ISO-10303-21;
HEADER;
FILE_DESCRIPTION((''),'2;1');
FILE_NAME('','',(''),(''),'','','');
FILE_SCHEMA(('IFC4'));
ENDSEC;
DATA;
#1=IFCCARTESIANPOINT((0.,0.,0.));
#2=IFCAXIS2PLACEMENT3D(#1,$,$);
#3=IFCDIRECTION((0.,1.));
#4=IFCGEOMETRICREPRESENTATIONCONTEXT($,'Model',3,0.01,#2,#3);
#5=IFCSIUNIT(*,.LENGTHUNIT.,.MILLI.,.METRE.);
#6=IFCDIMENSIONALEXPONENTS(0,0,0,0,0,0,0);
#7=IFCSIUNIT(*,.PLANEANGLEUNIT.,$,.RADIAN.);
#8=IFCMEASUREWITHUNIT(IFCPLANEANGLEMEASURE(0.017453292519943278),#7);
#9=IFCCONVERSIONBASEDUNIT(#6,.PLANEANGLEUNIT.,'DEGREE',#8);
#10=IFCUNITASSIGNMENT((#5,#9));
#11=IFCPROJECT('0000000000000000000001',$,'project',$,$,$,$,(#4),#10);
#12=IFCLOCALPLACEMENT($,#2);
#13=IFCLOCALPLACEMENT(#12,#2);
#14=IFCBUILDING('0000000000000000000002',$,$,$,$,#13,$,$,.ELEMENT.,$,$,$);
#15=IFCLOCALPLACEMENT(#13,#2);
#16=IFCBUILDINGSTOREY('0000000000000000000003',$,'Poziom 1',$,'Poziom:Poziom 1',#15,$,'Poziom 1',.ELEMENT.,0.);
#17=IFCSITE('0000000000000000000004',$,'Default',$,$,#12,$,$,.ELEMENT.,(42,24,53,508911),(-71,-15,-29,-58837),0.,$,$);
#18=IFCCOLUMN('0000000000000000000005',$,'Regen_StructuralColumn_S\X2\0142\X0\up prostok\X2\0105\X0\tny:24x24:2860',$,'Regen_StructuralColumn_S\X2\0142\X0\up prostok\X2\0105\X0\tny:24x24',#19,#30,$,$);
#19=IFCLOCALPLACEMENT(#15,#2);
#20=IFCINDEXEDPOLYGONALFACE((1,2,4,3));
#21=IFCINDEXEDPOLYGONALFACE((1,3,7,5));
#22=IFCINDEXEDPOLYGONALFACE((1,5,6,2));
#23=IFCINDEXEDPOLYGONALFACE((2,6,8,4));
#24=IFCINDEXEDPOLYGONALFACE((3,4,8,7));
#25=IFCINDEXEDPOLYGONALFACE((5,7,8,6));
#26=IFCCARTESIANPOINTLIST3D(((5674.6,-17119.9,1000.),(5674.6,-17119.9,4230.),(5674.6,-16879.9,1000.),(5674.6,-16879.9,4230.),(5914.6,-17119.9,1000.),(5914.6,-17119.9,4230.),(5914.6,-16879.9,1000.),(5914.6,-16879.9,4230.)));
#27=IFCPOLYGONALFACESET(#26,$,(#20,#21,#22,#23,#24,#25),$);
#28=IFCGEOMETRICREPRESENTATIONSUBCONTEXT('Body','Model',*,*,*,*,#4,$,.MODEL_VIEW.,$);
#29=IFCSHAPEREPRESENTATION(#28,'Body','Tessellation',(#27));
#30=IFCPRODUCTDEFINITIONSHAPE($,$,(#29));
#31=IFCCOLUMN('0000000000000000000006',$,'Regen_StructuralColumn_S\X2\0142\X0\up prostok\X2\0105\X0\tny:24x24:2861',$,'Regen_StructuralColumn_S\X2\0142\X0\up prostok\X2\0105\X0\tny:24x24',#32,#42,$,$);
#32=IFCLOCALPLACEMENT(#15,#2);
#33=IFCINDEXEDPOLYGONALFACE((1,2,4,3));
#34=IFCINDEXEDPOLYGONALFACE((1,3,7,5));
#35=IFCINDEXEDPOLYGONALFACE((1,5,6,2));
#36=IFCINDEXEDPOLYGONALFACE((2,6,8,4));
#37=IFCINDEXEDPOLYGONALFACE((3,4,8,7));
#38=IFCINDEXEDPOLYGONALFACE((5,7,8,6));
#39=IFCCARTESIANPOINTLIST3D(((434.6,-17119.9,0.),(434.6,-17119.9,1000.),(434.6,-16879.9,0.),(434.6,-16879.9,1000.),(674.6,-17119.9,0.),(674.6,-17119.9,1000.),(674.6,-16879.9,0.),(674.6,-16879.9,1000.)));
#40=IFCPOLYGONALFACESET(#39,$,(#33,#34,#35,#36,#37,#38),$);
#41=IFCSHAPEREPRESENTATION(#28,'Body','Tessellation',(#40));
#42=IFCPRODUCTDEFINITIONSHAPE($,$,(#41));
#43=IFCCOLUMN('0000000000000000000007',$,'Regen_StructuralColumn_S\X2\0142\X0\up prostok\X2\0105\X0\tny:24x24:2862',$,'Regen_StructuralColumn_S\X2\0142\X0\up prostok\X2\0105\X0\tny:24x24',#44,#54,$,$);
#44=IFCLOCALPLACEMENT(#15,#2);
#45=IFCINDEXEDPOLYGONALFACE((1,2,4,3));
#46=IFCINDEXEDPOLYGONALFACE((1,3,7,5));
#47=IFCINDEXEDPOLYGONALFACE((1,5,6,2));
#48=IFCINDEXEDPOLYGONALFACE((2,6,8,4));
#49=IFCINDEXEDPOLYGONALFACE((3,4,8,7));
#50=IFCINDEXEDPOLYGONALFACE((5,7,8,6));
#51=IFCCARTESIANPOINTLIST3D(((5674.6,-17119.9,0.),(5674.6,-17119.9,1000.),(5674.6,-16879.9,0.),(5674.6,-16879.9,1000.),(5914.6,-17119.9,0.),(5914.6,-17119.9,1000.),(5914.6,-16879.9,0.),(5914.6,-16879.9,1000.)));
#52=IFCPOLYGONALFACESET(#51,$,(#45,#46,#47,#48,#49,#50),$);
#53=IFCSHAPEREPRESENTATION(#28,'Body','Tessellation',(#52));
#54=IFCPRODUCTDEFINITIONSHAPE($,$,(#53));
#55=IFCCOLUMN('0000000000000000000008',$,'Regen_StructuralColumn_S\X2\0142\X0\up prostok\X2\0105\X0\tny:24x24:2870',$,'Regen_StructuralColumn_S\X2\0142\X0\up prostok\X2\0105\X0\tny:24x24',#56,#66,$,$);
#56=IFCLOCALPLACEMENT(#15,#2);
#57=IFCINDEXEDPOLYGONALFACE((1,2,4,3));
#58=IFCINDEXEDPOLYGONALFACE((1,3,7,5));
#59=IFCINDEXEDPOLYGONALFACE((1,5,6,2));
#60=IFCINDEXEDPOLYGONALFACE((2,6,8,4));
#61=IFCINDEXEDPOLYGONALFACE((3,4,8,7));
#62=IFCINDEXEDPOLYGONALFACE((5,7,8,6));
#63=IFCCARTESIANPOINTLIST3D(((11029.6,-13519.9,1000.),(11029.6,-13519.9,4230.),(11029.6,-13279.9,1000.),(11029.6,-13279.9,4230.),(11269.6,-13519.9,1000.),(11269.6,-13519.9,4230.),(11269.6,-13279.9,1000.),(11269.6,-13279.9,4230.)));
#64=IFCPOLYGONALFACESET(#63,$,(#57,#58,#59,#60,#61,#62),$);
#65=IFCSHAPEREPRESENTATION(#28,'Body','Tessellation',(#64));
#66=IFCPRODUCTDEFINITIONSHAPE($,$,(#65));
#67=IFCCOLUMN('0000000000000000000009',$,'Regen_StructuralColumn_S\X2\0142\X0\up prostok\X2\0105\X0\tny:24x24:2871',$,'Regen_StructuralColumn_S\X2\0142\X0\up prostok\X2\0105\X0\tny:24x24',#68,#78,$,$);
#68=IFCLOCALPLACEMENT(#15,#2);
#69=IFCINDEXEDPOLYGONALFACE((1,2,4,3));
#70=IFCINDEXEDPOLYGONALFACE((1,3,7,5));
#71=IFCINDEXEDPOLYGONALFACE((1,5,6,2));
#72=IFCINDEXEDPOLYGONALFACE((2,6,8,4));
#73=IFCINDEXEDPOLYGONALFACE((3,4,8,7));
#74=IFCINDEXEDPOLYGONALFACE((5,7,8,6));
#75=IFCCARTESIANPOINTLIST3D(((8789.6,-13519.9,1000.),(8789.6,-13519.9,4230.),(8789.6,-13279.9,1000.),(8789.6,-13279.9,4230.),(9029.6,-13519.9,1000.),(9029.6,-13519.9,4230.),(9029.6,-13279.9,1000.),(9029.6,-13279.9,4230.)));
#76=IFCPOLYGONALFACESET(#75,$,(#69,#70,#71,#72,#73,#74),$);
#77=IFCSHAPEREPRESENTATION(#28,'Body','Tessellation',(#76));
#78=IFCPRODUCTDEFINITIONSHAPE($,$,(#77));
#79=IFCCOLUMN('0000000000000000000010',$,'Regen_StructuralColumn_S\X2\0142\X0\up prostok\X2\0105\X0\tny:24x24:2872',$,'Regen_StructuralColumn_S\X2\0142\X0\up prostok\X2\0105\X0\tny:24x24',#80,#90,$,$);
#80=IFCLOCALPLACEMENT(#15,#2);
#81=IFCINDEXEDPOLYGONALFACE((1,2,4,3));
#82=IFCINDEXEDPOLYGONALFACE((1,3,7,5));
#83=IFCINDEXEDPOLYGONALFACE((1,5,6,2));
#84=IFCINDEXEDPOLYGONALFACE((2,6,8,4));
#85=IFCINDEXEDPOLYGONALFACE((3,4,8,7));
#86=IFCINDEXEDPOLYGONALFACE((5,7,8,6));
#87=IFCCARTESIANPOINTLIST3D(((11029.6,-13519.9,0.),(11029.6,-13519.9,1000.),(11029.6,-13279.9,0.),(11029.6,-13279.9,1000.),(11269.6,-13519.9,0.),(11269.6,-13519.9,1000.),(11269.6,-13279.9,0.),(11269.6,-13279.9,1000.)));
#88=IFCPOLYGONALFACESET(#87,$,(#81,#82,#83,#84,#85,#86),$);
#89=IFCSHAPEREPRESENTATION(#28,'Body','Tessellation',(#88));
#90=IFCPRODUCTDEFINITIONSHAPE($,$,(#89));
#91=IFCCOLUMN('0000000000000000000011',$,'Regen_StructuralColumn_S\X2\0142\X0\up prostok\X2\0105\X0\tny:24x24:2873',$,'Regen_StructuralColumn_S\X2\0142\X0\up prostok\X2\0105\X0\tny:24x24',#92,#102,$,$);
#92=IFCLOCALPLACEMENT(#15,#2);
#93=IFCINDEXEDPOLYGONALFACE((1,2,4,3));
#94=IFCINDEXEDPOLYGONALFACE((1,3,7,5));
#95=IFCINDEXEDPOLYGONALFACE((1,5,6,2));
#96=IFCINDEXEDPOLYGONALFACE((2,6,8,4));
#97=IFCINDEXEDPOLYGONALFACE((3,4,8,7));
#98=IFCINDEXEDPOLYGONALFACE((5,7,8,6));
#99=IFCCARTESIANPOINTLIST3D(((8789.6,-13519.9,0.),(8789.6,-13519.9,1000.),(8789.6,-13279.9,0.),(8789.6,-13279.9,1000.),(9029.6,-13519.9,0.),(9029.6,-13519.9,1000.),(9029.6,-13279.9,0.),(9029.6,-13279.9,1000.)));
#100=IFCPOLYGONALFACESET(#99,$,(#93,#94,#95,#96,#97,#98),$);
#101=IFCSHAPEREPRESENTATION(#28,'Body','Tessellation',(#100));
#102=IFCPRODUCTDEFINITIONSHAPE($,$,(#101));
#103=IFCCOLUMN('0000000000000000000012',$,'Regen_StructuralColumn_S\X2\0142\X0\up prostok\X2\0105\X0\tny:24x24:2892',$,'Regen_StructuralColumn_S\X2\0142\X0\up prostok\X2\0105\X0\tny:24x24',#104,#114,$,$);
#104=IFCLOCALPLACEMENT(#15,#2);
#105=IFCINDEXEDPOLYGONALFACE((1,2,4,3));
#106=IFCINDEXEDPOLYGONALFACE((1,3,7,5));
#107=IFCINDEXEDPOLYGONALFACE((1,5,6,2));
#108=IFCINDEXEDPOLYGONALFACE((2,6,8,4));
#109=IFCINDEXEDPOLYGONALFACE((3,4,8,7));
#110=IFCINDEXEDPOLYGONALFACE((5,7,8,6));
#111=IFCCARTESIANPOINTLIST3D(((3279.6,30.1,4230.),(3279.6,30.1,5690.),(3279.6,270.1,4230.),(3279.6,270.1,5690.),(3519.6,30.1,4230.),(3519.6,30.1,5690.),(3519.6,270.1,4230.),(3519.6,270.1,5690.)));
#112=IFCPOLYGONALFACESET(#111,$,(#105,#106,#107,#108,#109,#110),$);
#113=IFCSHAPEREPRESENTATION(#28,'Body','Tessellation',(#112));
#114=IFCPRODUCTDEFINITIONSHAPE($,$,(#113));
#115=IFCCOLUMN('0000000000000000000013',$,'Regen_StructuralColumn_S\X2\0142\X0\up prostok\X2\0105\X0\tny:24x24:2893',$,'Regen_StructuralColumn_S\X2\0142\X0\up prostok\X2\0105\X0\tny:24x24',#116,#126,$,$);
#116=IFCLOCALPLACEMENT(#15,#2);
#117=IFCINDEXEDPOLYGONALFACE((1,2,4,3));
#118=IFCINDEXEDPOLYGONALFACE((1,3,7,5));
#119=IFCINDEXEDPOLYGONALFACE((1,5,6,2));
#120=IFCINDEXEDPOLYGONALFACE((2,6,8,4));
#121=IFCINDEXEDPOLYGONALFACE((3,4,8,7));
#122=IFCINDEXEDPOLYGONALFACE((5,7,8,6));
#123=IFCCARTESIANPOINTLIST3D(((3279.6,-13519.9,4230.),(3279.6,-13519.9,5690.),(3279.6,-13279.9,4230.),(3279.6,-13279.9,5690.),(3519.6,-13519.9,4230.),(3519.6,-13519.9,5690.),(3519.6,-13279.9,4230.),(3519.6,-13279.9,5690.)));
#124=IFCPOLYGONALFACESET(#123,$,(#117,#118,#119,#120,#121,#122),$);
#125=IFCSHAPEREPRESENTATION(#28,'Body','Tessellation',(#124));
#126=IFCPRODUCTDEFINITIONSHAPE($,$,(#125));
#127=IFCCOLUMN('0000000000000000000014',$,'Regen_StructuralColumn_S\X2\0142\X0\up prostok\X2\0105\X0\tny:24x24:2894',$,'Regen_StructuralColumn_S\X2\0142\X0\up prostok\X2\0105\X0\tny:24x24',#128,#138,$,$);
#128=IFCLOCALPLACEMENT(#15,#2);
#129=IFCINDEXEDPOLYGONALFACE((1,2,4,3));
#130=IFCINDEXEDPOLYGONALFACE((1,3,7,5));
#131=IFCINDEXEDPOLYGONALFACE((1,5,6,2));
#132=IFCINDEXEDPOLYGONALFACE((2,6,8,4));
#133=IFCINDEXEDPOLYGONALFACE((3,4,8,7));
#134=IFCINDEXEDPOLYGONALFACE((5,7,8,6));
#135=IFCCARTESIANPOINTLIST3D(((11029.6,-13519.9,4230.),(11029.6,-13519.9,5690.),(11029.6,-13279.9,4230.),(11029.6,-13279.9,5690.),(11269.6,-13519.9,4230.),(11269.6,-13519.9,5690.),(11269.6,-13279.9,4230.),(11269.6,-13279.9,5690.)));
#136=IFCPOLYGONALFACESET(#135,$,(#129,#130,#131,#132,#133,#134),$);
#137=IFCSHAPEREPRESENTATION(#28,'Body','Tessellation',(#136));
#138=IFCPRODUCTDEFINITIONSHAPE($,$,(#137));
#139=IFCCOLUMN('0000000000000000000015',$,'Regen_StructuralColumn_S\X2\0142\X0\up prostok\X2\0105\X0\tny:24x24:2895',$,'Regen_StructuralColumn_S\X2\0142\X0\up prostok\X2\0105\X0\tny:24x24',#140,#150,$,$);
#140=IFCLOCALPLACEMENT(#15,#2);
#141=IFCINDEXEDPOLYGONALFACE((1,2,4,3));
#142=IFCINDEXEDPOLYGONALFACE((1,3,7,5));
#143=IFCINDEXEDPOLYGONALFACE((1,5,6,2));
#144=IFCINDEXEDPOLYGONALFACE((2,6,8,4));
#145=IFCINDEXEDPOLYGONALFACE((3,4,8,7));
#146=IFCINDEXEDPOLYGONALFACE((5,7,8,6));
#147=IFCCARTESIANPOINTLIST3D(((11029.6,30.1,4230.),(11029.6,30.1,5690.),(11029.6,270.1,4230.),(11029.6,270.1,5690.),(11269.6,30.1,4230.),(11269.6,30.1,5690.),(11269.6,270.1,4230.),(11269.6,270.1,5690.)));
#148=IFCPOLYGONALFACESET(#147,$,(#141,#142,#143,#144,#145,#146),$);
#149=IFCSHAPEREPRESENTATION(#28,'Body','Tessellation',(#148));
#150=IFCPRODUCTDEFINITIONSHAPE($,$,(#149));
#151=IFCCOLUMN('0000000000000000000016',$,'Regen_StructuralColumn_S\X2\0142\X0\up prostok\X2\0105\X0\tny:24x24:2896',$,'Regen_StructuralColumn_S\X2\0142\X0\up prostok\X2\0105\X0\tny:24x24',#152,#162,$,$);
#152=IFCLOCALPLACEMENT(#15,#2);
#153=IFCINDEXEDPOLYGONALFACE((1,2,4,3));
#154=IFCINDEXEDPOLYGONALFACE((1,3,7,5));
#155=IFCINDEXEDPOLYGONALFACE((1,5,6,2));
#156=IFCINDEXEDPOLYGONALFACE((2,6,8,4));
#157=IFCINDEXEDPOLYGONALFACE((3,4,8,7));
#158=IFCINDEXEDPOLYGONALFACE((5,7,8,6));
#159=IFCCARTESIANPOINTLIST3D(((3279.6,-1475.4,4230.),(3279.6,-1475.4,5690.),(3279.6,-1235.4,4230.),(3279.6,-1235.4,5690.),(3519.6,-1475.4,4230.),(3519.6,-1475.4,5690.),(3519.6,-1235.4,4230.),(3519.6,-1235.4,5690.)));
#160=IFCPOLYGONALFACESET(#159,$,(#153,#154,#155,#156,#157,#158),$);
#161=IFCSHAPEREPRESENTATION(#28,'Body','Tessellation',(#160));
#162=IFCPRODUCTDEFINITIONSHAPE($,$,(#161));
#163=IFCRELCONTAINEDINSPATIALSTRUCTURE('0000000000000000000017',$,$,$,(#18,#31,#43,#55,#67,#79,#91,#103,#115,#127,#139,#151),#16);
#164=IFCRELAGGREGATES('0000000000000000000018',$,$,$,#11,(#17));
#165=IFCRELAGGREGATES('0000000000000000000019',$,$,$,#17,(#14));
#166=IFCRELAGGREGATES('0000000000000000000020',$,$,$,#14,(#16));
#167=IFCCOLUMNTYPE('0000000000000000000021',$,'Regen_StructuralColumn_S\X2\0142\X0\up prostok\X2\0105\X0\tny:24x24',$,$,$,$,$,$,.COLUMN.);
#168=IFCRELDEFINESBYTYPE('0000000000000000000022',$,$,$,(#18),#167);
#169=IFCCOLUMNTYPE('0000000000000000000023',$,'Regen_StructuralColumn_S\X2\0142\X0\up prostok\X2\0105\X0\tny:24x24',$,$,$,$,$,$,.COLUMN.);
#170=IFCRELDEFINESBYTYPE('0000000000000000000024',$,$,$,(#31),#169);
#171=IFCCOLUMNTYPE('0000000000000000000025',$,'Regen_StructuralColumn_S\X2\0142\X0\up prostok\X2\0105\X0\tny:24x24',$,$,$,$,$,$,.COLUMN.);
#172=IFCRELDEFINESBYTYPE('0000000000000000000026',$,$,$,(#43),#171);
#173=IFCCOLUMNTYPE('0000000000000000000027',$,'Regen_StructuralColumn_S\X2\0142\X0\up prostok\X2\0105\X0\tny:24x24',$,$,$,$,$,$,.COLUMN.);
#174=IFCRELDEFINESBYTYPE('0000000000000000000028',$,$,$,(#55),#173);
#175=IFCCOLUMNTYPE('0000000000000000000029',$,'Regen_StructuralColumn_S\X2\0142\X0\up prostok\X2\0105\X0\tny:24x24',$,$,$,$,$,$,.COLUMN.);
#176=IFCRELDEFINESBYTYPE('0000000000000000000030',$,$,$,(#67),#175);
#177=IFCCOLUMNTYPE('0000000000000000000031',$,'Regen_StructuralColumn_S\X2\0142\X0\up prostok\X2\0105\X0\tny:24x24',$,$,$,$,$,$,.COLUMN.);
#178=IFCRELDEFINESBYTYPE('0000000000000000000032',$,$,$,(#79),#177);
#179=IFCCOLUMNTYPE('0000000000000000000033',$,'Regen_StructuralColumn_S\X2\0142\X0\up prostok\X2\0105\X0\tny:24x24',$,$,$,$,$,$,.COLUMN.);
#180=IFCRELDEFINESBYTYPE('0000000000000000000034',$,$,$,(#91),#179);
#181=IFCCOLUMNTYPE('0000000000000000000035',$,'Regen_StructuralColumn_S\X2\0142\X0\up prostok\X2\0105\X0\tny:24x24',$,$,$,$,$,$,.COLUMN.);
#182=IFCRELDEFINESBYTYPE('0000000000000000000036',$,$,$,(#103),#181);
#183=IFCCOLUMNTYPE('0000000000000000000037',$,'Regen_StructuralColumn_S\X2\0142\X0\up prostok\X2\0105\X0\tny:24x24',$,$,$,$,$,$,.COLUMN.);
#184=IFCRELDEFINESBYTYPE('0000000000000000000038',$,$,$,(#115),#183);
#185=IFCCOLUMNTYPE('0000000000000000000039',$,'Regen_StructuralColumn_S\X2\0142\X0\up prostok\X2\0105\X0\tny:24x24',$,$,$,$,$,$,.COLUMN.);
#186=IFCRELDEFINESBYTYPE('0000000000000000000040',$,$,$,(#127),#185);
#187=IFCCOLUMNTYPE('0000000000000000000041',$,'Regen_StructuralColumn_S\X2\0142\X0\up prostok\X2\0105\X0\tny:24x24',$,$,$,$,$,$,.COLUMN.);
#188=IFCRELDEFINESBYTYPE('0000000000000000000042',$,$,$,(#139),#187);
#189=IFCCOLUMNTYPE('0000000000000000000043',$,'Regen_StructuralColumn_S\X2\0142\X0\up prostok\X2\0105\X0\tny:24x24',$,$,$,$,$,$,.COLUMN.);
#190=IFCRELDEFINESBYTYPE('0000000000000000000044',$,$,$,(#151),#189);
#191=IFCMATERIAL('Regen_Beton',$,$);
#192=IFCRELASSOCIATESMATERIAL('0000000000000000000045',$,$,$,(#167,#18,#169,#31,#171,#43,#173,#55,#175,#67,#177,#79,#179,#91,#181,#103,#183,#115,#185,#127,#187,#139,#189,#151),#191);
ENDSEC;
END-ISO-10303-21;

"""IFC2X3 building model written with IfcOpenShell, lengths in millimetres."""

from ifc_helpers import new_model, entity, si_unit, converted_unit, direction, frame, frame_2d, origin, place, context, subcontext, project, spatial, rectangle, extrude, source, transform, mapped, material, type_object, type_shapes, element, save


model = new_model("IFC2X3")

# Units and contexts
model_context = context("Model", 3, precision=0.01, world=origin(), true_north=direction((0.0, 1.0)))
body_context = subcontext(model_context, "Body", "Model", "MODEL_VIEW")
ifc_project = project(units=[si_unit("LENGTHUNIT", "METRE", prefix="MILLI"), converted_unit("PLANEANGLEUNIT", "DEGREE", entity("IfcPlaneAngleMeasure", 0.017453292519943278), si_unit("PLANEANGLEUNIT", "RADIAN"), dimensions=[0, 0, 0, 0, 0, 0, 0])], contexts=[model_context])

# Site, building, storey
site_placement = place(None, origin())
site = spatial("IfcSite", under=ifc_project, at=site_placement, Name="Default", CompositionType="ELEMENT", RefLatitude=(42, 24, 53, 508911), RefLongitude=(-71, -15, -29, -58837), RefElevation=0.0)
building_placement = place(site_placement, origin())
building = spatial("IfcBuilding", under=site, at=building_placement, CompositionType="ELEMENT")
storey_placement = place(building_placement, origin())
storey = spatial("IfcBuildingStorey", under=building, at=storey_placement, Name="Poziom 1", ObjectType="Poziom:Poziom 1", LongName="Poziom 1", CompositionType="ELEMENT", Elevation=0.0)

# Columns
ifc_material_1 = material(Name="Regen_Beton")
column_type_1 = type_object("IfcColumnType", Name="Regen_StructuralColumn_Słup prostokątny:24x24", PredefinedType="COLUMN", material=ifc_material_1)
shared_shape_1 = source(origin(), body_context, "Body", "SweptSolid", [
    extrude(rectangle(XDim=240.0, YDim=240.0, at=frame_2d((0.0, 0.0), x_axis=(1.0, 0.0))), frame((5794.6, -16999.9, 1000.0), z_axis=(0.0, 0.0, 1.0), x_axis=(-1.0, 0.0, 0.0)), (0.0, 0.0, 1.0), 3230.0),
])
type_shapes(column_type_1, [shared_shape_1])
column_1_placement = place(storey_placement, origin())
element("IfcColumn", 1, at=column_1_placement, inside=storey, type_object=column_type_1, material=ifc_material_1, Name="Regen_StructuralColumn_Słup prostokątny:24x24:2860", ObjectType="Regen_StructuralColumn_Słup prostokątny:24x24", context=body_context, shape_type="MappedRepresentation", body=[
    mapped(shared_shape_1, transform((0.0, 0.0, 0.0), scale=1.0)),
])
column_type_2 = type_object("IfcColumnType", Name="Regen_StructuralColumn_Słup prostokątny:24x24", PredefinedType="COLUMN", material=ifc_material_1)
shared_shape_2 = source(origin(), body_context, "Body", "SweptSolid", [
    extrude(rectangle(XDim=240.0, YDim=240.0, at=frame_2d((0.0, 0.0), x_axis=(1.0, 0.0))), frame((554.6, -16999.9, 0.0), z_axis=(0.0, 0.0, 1.0), x_axis=(-1.0, 0.0, 0.0)), (0.0, 0.0, 1.0), 1000.0),
])
type_shapes(column_type_2, [shared_shape_2])
column_2_placement = place(storey_placement, origin())
element("IfcColumn", 2, at=column_2_placement, inside=storey, type_object=column_type_2, material=ifc_material_1, Name="Regen_StructuralColumn_Słup prostokątny:24x24:2861", ObjectType="Regen_StructuralColumn_Słup prostokątny:24x24", context=body_context, shape_type="MappedRepresentation", body=[
    mapped(shared_shape_2, transform((0.0, 0.0, 0.0), scale=1.0)),
])
column_type_3 = type_object("IfcColumnType", Name="Regen_StructuralColumn_Słup prostokątny:24x24", PredefinedType="COLUMN", material=ifc_material_1)
shared_shape_3 = source(origin(), body_context, "Body", "SweptSolid", [
    extrude(rectangle(XDim=240.0, YDim=240.0, at=frame_2d((0.0, 0.0), x_axis=(1.0, 0.0))), frame((5794.6, -16999.9, 0.0), z_axis=(0.0, 0.0, 1.0), x_axis=(-1.0, 0.0, 0.0)), (0.0, 0.0, 1.0), 1000.0),
])
type_shapes(column_type_3, [shared_shape_3])
column_3_placement = place(storey_placement, origin())
element("IfcColumn", 3, at=column_3_placement, inside=storey, type_object=column_type_3, material=ifc_material_1, Name="Regen_StructuralColumn_Słup prostokątny:24x24:2862", ObjectType="Regen_StructuralColumn_Słup prostokątny:24x24", context=body_context, shape_type="MappedRepresentation", body=[
    mapped(shared_shape_3, transform((0.0, 0.0, 0.0), scale=1.0)),
])
column_type_4 = type_object("IfcColumnType", Name="Regen_StructuralColumn_Słup prostokątny:24x24", PredefinedType="COLUMN", material=ifc_material_1)
shared_shape_4 = source(origin(), body_context, "Body", "SweptSolid", [
    extrude(rectangle(XDim=240.0, YDim=240.0, at=frame_2d((0.0, 0.0), x_axis=(1.0, 0.0))), frame((11149.6, -13399.9, 1000.0), z_axis=(0.0, 0.0, 1.0), x_axis=(-1.0, 0.0, 0.0)), (0.0, 0.0, 1.0), 3230.0),
])
type_shapes(column_type_4, [shared_shape_4])
column_4_placement = place(storey_placement, origin())
element("IfcColumn", 4, at=column_4_placement, inside=storey, type_object=column_type_4, material=ifc_material_1, Name="Regen_StructuralColumn_Słup prostokątny:24x24:2870", ObjectType="Regen_StructuralColumn_Słup prostokątny:24x24", context=body_context, shape_type="MappedRepresentation", body=[
    mapped(shared_shape_4, transform((0.0, 0.0, 0.0), scale=1.0)),
])
column_type_5 = type_object("IfcColumnType", Name="Regen_StructuralColumn_Słup prostokątny:24x24", PredefinedType="COLUMN", material=ifc_material_1)
shared_shape_5 = source(origin(), body_context, "Body", "SweptSolid", [
    extrude(rectangle(XDim=240.0, YDim=240.0, at=frame_2d((0.0, 0.0), x_axis=(1.0, 0.0))), frame((8909.6, -13399.9, 1000.0), z_axis=(0.0, 0.0, 1.0), x_axis=(-1.0, 0.0, 0.0)), (0.0, 0.0, 1.0), 3230.0),
])
type_shapes(column_type_5, [shared_shape_5])
column_5_placement = place(storey_placement, origin())
element("IfcColumn", 5, at=column_5_placement, inside=storey, type_object=column_type_5, material=ifc_material_1, Name="Regen_StructuralColumn_Słup prostokątny:24x24:2871", ObjectType="Regen_StructuralColumn_Słup prostokątny:24x24", context=body_context, shape_type="MappedRepresentation", body=[
    mapped(shared_shape_5, transform((0.0, 0.0, 0.0), scale=1.0)),
])
column_type_6 = type_object("IfcColumnType", Name="Regen_StructuralColumn_Słup prostokątny:24x24", PredefinedType="COLUMN", material=ifc_material_1)
shared_shape_6 = source(origin(), body_context, "Body", "SweptSolid", [
    extrude(rectangle(XDim=240.0, YDim=240.0, at=frame_2d((0.0, 0.0), x_axis=(1.0, 0.0))), frame((11149.6, -13399.9, 0.0), z_axis=(0.0, 0.0, 1.0), x_axis=(-1.0, 0.0, 0.0)), (0.0, 0.0, 1.0), 1000.0),
])
type_shapes(column_type_6, [shared_shape_6])
column_6_placement = place(storey_placement, origin())
element("IfcColumn", 6, at=column_6_placement, inside=storey, type_object=column_type_6, material=ifc_material_1, Name="Regen_StructuralColumn_Słup prostokątny:24x24:2872", ObjectType="Regen_StructuralColumn_Słup prostokątny:24x24", context=body_context, shape_type="MappedRepresentation", body=[
    mapped(shared_shape_6, transform((0.0, 0.0, 0.0), scale=1.0)),
])
column_type_7 = type_object("IfcColumnType", Name="Regen_StructuralColumn_Słup prostokątny:24x24", PredefinedType="COLUMN", material=ifc_material_1)
shared_shape_7 = source(origin(), body_context, "Body", "SweptSolid", [
    extrude(rectangle(XDim=240.0, YDim=240.0, at=frame_2d((0.0, 0.0), x_axis=(1.0, 0.0))), frame((8909.6, -13399.9, 0.0), z_axis=(0.0, 0.0, 1.0), x_axis=(-1.0, 0.0, 0.0)), (0.0, 0.0, 1.0), 1000.0),
])
type_shapes(column_type_7, [shared_shape_7])
column_7_placement = place(storey_placement, origin())
element("IfcColumn", 7, at=column_7_placement, inside=storey, type_object=column_type_7, material=ifc_material_1, Name="Regen_StructuralColumn_Słup prostokątny:24x24:2873", ObjectType="Regen_StructuralColumn_Słup prostokątny:24x24", context=body_context, shape_type="MappedRepresentation", body=[
    mapped(shared_shape_7, transform((0.0, 0.0, 0.0), scale=1.0)),
])
column_type_8 = type_object("IfcColumnType", Name="Regen_StructuralColumn_Słup prostokątny:24x24", PredefinedType="COLUMN", material=ifc_material_1)
shared_shape_8 = source(origin(), body_context, "Body", "SweptSolid", [
    extrude(rectangle(XDim=240.0, YDim=240.0, at=frame_2d((0.0, 0.0), x_axis=(1.0, 0.0))), frame((3399.6, 150.1, 4230.0), z_axis=(0.0, 0.0, 1.0), x_axis=(-1.0, 0.0, 0.0)), (0.0, 0.0, 1.0), 1460.0),
])
type_shapes(column_type_8, [shared_shape_8])
column_8_placement = place(storey_placement, origin())
element("IfcColumn", 8, at=column_8_placement, inside=storey, type_object=column_type_8, material=ifc_material_1, Name="Regen_StructuralColumn_Słup prostokątny:24x24:2892", ObjectType="Regen_StructuralColumn_Słup prostokątny:24x24", context=body_context, shape_type="MappedRepresentation", body=[
    mapped(shared_shape_8, transform((0.0, 0.0, 0.0), scale=1.0)),
])
column_type_9 = type_object("IfcColumnType", Name="Regen_StructuralColumn_Słup prostokątny:24x24", PredefinedType="COLUMN", material=ifc_material_1)
shared_shape_9 = source(origin(), body_context, "Body", "SweptSolid", [
    extrude(rectangle(XDim=240.0, YDim=240.0, at=frame_2d((0.0, 0.0), x_axis=(1.0, 0.0))), frame((3399.6, -13399.9, 4230.0), z_axis=(0.0, 0.0, 1.0), x_axis=(-1.0, 0.0, 0.0)), (0.0, 0.0, 1.0), 1460.0),
])
type_shapes(column_type_9, [shared_shape_9])
column_9_placement = place(storey_placement, origin())
element("IfcColumn", 9, at=column_9_placement, inside=storey, type_object=column_type_9, material=ifc_material_1, Name="Regen_StructuralColumn_Słup prostokątny:24x24:2893", ObjectType="Regen_StructuralColumn_Słup prostokątny:24x24", context=body_context, shape_type="MappedRepresentation", body=[
    mapped(shared_shape_9, transform((0.0, 0.0, 0.0), scale=1.0)),
])
column_type_10 = type_object("IfcColumnType", Name="Regen_StructuralColumn_Słup prostokątny:24x24", PredefinedType="COLUMN", material=ifc_material_1)
shared_shape_10 = source(origin(), body_context, "Body", "SweptSolid", [
    extrude(rectangle(XDim=240.0, YDim=240.0, at=frame_2d((0.0, 0.0), x_axis=(1.0, 0.0))), frame((11149.6, -13399.9, 4230.0), z_axis=(0.0, 0.0, 1.0), x_axis=(-1.0, 0.0, 0.0)), (0.0, 0.0, 1.0), 1460.0),
])
type_shapes(column_type_10, [shared_shape_10])
column_10_placement = place(storey_placement, origin())
element("IfcColumn", 10, at=column_10_placement, inside=storey, type_object=column_type_10, material=ifc_material_1, Name="Regen_StructuralColumn_Słup prostokątny:24x24:2894", ObjectType="Regen_StructuralColumn_Słup prostokątny:24x24", context=body_context, shape_type="MappedRepresentation", body=[
    mapped(shared_shape_10, transform((0.0, 0.0, 0.0), scale=1.0)),
])
column_type_11 = type_object("IfcColumnType", Name="Regen_StructuralColumn_Słup prostokątny:24x24", PredefinedType="COLUMN", material=ifc_material_1)
shared_shape_11 = source(origin(), body_context, "Body", "SweptSolid", [
    extrude(rectangle(XDim=240.0, YDim=240.0, at=frame_2d((0.0, 0.0), x_axis=(1.0, 0.0))), frame((11149.6, 150.1, 4230.0), z_axis=(0.0, 0.0, 1.0), x_axis=(-1.0, 0.0, 0.0)), (0.0, 0.0, 1.0), 1460.0),
])
type_shapes(column_type_11, [shared_shape_11])
column_11_placement = place(storey_placement, origin())
element("IfcColumn", 11, at=column_11_placement, inside=storey, type_object=column_type_11, material=ifc_material_1, Name="Regen_StructuralColumn_Słup prostokątny:24x24:2895", ObjectType="Regen_StructuralColumn_Słup prostokątny:24x24", context=body_context, shape_type="MappedRepresentation", body=[
    mapped(shared_shape_11, transform((0.0, 0.0, 0.0), scale=1.0)),
])
column_type_12 = type_object("IfcColumnType", Name="Regen_StructuralColumn_Słup prostokątny:24x24", PredefinedType="COLUMN", material=ifc_material_1)
shared_shape_12 = source(origin(), body_context, "Body", "SweptSolid", [
    extrude(rectangle(XDim=240.0, YDim=240.0, at=frame_2d((0.0, 0.0), x_axis=(1.0, 0.0))), frame((3399.6, -1355.4, 4230.0), z_axis=(0.0, 0.0, 1.0), x_axis=(-1.0, 0.0, 0.0)), (0.0, 0.0, 1.0), 1460.0),
])
type_shapes(column_type_12, [shared_shape_12])
column_12_placement = place(storey_placement, origin())
element("IfcColumn", 12, at=column_12_placement, inside=storey, type_object=column_type_12, material=ifc_material_1, Name="Regen_StructuralColumn_Słup prostokątny:24x24:2896", ObjectType="Regen_StructuralColumn_Słup prostokątny:24x24", context=body_context, shape_type="MappedRepresentation", body=[
    mapped(shared_shape_12, transform((0.0, 0.0, 0.0), scale=1.0)),
])

save(model, "model.ifc")
